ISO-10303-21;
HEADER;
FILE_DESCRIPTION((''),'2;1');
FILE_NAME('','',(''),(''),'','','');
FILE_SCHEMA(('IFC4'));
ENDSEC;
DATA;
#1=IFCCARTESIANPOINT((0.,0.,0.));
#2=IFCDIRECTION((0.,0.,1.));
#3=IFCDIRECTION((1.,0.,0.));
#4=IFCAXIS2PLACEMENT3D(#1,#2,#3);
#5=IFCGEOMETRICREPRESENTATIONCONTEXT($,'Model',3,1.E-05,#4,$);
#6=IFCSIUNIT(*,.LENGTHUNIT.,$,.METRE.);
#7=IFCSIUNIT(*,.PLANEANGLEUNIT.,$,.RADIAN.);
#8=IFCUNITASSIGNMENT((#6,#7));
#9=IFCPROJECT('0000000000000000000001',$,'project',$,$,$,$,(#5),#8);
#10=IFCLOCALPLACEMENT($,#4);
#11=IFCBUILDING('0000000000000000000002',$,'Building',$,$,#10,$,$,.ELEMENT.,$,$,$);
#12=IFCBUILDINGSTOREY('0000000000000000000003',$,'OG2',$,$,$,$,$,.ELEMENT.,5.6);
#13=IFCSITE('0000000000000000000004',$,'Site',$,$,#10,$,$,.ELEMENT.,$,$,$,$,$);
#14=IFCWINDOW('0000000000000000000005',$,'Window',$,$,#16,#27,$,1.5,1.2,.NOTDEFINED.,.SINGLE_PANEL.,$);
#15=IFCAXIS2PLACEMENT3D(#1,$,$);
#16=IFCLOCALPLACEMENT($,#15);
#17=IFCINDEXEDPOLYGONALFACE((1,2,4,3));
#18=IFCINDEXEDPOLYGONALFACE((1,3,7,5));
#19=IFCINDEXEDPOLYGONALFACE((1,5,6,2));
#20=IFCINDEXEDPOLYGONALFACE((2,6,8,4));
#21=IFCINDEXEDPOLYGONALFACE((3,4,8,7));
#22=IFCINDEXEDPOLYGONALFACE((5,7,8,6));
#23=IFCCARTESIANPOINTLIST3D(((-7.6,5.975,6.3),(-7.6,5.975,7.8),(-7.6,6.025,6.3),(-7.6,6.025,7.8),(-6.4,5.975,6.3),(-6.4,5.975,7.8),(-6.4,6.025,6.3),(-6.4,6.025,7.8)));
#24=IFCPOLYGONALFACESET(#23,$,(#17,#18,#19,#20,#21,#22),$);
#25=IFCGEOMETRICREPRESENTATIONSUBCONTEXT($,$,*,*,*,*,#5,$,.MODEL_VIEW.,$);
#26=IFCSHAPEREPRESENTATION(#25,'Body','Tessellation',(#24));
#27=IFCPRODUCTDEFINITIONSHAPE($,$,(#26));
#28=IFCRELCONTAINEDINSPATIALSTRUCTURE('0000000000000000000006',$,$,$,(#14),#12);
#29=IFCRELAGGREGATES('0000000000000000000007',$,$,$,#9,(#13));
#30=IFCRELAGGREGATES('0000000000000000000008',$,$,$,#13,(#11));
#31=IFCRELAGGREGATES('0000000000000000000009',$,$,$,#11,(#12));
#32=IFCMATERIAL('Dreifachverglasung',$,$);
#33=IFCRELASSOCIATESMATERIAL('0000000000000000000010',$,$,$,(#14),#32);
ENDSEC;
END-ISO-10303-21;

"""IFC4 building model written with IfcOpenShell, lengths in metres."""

from ifc_helpers import new_model, si_unit, frame, origin, origin_with_axes, origin_2d, place, context, subcontext, project, spatial, rectangle, extrude, material, element, save


model = new_model("IFC4")

# Units and contexts
model_context = context("Model", 3, precision=1e-05, world=origin_with_axes())
sub_context = subcontext(model_context, None, None, "MODEL_VIEW")
ifc_project = project(units=[si_unit("LENGTHUNIT", "METRE"), si_unit("PLANEANGLEUNIT", "RADIAN")], contexts=[model_context])

# Site, building, storey
placement_1 = place(None, origin_with_axes())
site = spatial("IfcSite", under=ifc_project, at=placement_1, Name="Site", CompositionType="ELEMENT")
building = spatial("IfcBuilding", under=site, at=placement_1, Name="Building", CompositionType="ELEMENT")
storey = spatial("IfcBuildingStorey", under=building, Name="OG2", CompositionType="ELEMENT", Elevation=5.6)

# Window
ifc_material = material(Name="Dreifachverglasung")
placement_2 = place(None, origin_with_axes())
window_placement = place(placement_2, frame((-7.0, 6.0, 6.3)))
element("IfcWindow", 1, at=window_placement, inside=storey, material=ifc_material, Name="Window", OverallHeight=1.5, OverallWidth=1.2, PartitioningType="SINGLE_PANEL", PredefinedType="NOTDEFINED", context=sub_context, shape_type="SweptSolid", body=[
    extrude(rectangle(XDim=1.2, YDim=0.05, at=origin_2d()), origin(), (0.0, 0.0, 1.0), 1.5),
])

save(model, "model.ifc")
